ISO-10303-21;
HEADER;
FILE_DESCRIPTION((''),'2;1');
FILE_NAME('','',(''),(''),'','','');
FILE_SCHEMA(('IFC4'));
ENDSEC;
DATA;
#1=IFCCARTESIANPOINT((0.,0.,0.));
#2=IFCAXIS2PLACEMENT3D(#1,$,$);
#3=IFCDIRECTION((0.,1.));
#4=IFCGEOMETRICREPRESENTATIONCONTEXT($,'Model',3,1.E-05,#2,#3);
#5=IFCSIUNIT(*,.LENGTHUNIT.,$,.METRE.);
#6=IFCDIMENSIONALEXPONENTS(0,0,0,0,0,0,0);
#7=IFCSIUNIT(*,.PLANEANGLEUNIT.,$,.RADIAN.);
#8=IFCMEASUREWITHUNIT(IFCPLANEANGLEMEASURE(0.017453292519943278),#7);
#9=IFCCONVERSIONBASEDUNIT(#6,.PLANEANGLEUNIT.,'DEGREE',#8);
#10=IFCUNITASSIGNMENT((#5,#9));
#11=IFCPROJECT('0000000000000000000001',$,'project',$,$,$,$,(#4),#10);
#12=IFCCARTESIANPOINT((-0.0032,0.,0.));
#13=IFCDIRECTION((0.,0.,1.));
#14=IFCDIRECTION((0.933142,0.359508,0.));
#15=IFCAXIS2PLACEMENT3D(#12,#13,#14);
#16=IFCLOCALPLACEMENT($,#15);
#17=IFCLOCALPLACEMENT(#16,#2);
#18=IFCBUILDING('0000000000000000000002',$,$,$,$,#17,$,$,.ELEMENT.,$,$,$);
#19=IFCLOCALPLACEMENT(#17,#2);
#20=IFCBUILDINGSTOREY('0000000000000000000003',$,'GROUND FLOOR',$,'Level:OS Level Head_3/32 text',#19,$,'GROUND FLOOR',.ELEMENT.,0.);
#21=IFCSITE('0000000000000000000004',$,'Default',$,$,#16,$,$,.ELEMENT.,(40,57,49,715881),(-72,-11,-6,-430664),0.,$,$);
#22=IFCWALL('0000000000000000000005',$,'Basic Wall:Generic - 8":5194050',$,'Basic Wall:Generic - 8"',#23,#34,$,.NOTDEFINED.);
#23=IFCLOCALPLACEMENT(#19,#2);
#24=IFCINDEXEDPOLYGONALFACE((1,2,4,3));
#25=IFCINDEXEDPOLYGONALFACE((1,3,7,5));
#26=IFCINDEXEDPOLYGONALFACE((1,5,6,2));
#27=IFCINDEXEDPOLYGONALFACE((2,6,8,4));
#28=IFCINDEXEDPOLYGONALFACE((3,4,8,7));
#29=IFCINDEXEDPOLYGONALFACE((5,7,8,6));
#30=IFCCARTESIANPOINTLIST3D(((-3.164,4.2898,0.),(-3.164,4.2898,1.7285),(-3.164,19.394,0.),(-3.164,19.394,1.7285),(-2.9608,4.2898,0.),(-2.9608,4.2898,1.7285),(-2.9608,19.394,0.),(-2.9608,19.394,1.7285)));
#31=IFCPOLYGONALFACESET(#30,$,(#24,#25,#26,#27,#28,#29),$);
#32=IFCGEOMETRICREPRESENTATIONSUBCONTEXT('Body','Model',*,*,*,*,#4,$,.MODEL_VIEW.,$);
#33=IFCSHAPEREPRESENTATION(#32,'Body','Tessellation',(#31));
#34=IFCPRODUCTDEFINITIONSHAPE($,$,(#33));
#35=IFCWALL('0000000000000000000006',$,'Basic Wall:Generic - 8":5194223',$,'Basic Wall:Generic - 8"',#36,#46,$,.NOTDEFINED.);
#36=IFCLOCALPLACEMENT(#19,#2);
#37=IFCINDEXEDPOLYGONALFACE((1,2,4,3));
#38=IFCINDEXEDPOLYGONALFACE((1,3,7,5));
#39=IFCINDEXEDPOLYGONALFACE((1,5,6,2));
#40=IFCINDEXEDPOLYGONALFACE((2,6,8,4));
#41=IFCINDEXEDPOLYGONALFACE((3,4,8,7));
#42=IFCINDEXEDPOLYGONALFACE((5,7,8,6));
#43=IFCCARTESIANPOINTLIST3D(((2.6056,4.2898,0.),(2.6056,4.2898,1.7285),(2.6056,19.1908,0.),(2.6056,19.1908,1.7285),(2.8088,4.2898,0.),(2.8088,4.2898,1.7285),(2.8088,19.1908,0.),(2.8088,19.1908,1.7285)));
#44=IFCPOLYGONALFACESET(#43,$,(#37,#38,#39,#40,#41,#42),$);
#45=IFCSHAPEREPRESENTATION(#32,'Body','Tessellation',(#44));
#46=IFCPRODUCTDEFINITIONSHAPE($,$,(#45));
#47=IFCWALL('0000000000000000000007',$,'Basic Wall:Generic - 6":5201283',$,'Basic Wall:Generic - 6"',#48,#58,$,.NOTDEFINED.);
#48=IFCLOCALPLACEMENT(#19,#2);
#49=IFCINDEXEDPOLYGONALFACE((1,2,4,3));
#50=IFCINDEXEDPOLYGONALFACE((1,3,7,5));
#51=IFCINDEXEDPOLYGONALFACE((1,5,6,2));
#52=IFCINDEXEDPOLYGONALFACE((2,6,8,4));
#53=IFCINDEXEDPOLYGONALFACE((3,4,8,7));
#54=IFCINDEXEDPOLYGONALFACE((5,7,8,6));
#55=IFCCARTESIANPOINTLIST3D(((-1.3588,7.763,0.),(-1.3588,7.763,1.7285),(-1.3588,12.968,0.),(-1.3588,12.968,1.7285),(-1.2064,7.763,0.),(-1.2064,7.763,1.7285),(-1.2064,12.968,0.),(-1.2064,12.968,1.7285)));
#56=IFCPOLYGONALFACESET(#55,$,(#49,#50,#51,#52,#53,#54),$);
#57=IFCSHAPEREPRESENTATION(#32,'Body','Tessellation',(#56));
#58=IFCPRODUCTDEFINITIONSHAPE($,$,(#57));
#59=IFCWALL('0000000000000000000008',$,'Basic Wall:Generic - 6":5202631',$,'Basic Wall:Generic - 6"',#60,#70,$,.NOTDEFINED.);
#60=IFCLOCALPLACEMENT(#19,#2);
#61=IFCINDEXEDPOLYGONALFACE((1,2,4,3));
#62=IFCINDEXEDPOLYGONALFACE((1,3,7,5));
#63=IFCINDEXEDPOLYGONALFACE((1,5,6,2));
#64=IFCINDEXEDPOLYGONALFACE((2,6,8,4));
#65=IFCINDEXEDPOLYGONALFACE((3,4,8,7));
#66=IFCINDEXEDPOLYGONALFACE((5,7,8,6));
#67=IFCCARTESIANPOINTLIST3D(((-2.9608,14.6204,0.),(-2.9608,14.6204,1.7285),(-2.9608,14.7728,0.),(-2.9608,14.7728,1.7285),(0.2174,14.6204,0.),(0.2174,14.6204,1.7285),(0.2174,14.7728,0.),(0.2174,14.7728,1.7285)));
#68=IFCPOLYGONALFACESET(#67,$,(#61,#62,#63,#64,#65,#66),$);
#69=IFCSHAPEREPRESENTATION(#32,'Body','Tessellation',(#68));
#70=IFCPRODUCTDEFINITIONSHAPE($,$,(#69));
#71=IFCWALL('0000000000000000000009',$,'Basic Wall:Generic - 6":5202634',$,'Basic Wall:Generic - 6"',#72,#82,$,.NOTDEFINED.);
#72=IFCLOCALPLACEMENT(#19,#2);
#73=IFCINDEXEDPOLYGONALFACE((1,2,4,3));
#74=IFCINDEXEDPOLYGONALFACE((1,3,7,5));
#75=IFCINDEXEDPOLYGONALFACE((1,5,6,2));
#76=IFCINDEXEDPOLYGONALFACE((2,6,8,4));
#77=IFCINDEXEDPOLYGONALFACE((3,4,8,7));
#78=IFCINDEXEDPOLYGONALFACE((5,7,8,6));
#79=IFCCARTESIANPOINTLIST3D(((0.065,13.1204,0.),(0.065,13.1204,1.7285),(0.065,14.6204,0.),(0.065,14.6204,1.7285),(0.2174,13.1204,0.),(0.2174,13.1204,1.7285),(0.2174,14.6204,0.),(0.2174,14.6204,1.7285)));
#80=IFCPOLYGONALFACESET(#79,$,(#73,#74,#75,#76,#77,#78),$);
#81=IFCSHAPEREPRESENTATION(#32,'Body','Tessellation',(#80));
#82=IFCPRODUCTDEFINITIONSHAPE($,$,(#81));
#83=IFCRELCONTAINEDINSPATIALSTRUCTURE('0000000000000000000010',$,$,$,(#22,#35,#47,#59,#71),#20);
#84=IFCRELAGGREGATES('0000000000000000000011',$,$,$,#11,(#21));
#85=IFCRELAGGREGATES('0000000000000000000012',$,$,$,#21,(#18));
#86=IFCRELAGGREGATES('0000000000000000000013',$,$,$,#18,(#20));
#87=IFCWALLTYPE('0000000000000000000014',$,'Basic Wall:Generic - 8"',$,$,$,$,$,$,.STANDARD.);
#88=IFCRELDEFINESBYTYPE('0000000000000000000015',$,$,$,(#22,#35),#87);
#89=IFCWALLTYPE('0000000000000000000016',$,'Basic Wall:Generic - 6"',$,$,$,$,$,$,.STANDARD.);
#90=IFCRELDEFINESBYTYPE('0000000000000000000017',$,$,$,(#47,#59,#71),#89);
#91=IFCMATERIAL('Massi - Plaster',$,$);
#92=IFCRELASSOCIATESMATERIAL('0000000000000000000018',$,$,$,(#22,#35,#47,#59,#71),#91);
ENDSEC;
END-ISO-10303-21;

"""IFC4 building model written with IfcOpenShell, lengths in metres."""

from ifc_helpers import new_model, entity, si_unit, converted_unit, direction, frame, origin, place, context, subcontext, project, spatial, indexed_curve, outline, extrude, material, type_object, element, save


model = new_model("IFC4")

# Units and contexts
model_context = context("Model", 3, precision=1e-05, world=origin(), true_north=direction((0.0, 1.0)))
body_context = subcontext(model_context, "Body", "Model", "MODEL_VIEW")
ifc_project = project(units=[si_unit("LENGTHUNIT", "METRE"), converted_unit("PLANEANGLEUNIT", "DEGREE", entity("IfcPlaneAngleMeasure", 0.017453292519943278), si_unit("PLANEANGLEUNIT", "RADIAN"), dimensions=[0, 0, 0, 0, 0, 0, 0])], contexts=[model_context])

# Site, building, storey
site_placement = place(None, frame((-0.0032, 0.0, 0.0), z_axis=(0.0, 0.0, 1.0), x_axis=(0.933142, 0.359508, 0.0)))
site = spatial("IfcSite", under=ifc_project, at=site_placement, Name="Default", CompositionType="ELEMENT", RefLatitude=(40, 57, 49, 715881), RefLongitude=(-72, -11, -6, -430664), RefElevation=0.0)
building_placement = place(site_placement, origin())
building = spatial("IfcBuilding", under=site, at=building_placement, CompositionType="ELEMENT")
storey_placement = place(building_placement, origin())
storey = spatial("IfcBuildingStorey", under=building, at=storey_placement, Name="GROUND FLOOR", ObjectType="Level:OS Level Head_3/32 text", LongName="GROUND FLOOR", CompositionType="ELEMENT", Elevation=0.0)

# Walls
ifc_material_1 = material(Name="Massi - Plaster")
wall_type_1 = type_object("IfcWallType", Name="Basic Wall:Generic - 8\"", PredefinedType="STANDARD")
wall_1_placement = place(storey_placement, frame((-3.0624, 4.2898, 0.0), z_axis=(0.0, 0.0, 1.0), x_axis=(0.0, 1.0, 0.0)))
element("IfcWall", 1, at=wall_1_placement, inside=storey, type_object=wall_type_1, material=ifc_material_1, Name="Basic Wall:Generic - 8\":5194050", ObjectType="Basic Wall:Generic - 8\"", PredefinedType="NOTDEFINED", context=body_context, shape_type="SweptSolid", body=[
    extrude(outline(indexed_curve([(15.1042, 0.1016), (0.0, 0.1016), (0.0, -0.1016), (15.1042, -0.1016), (15.1042, 0.1016)], self_intersect=False)), origin(), (0.0, 0.0, 1.0), 1.7285),
])
wall_2_placement = place(storey_placement, frame((2.7072, 19.1908, 0.0), z_axis=(0.0, 0.0, 1.0), x_axis=(0.0, -1.0, 0.0)))
element("IfcWall", 2, at=wall_2_placement, inside=storey, type_object=wall_type_1, material=ifc_material_1, Name="Basic Wall:Generic - 8\":5194223", ObjectType="Basic Wall:Generic - 8\"", PredefinedType="NOTDEFINED", context=body_context, shape_type="SweptSolid", body=[
    extrude(outline(indexed_curve([(14.901, 0.1016), (0.0, 0.1016), (0.0, -0.1016), (14.901, -0.1016), (14.901, 0.1016)], self_intersect=False)), origin(), (0.0, 0.0, 1.0), 1.7285),
])
wall_type_2 = type_object("IfcWallType", Name="Basic Wall:Generic - 6\"", PredefinedType="STANDARD")
wall_3_placement = place(storey_placement, frame((-1.2826, 12.968, 0.0), z_axis=(0.0, 0.0, 1.0), x_axis=(0.0, -1.0, 0.0)))
element("IfcWall", 3, at=wall_3_placement, inside=storey, type_object=wall_type_2, material=ifc_material_1, Name="Basic Wall:Generic - 6\":5201283", ObjectType="Basic Wall:Generic - 6\"", PredefinedType="NOTDEFINED", context=body_context, shape_type="SweptSolid", body=[
    extrude(outline(indexed_curve([(5.205, 0.0762), (0.0, 0.0762), (0.0, -0.0762), (5.205, -0.0762), (5.205, 0.0762)], self_intersect=False)), origin(), (0.0, 0.0, 1.0), 1.7285),
])

# Walls
wall_4_placement = place(storey_placement, frame((0.2174, 14.6966, 0.0), z_axis=(0.0, 0.0, 1.0), x_axis=(-1.0, 0.0, 0.0)))
element("IfcWall", 4, at=wall_4_placement, inside=storey, type_object=wall_type_2, material=ifc_material_1, Name="Basic Wall:Generic - 6\":5202631", ObjectType="Basic Wall:Generic - 6\"", PredefinedType="NOTDEFINED", context=body_context, shape_type="SweptSolid", body=[
    extrude(outline(indexed_curve([(3.1782, 0.0762), (0.0, 0.0762), (0.0, -0.0762), (3.1782, -0.0762), (3.1782, 0.0762)], self_intersect=False)), origin(), (0.0, 0.0, 1.0), 1.7285),
])
wall_5_placement = place(storey_placement, frame((0.1412, 14.6204, 0.0), z_axis=(0.0, 0.0, 1.0), x_axis=(0.0, -1.0, 0.0)))
element("IfcWall", 5, at=wall_5_placement, inside=storey, type_object=wall_type_2, material=ifc_material_1, Name="Basic Wall:Generic - 6\":5202634", ObjectType="Basic Wall:Generic - 6\"", PredefinedType="NOTDEFINED", context=body_context, shape_type="SweptSolid", body=[
    extrude(outline(indexed_curve([(1.5, 0.0762), (0.0, 0.0762), (0.0, -0.0762), (1.5, -0.0762), (1.5, 0.0762)], self_intersect=False)), origin(), (0.0, 0.0, 1.0), 1.7285),
])

save(model, "model.ifc")
